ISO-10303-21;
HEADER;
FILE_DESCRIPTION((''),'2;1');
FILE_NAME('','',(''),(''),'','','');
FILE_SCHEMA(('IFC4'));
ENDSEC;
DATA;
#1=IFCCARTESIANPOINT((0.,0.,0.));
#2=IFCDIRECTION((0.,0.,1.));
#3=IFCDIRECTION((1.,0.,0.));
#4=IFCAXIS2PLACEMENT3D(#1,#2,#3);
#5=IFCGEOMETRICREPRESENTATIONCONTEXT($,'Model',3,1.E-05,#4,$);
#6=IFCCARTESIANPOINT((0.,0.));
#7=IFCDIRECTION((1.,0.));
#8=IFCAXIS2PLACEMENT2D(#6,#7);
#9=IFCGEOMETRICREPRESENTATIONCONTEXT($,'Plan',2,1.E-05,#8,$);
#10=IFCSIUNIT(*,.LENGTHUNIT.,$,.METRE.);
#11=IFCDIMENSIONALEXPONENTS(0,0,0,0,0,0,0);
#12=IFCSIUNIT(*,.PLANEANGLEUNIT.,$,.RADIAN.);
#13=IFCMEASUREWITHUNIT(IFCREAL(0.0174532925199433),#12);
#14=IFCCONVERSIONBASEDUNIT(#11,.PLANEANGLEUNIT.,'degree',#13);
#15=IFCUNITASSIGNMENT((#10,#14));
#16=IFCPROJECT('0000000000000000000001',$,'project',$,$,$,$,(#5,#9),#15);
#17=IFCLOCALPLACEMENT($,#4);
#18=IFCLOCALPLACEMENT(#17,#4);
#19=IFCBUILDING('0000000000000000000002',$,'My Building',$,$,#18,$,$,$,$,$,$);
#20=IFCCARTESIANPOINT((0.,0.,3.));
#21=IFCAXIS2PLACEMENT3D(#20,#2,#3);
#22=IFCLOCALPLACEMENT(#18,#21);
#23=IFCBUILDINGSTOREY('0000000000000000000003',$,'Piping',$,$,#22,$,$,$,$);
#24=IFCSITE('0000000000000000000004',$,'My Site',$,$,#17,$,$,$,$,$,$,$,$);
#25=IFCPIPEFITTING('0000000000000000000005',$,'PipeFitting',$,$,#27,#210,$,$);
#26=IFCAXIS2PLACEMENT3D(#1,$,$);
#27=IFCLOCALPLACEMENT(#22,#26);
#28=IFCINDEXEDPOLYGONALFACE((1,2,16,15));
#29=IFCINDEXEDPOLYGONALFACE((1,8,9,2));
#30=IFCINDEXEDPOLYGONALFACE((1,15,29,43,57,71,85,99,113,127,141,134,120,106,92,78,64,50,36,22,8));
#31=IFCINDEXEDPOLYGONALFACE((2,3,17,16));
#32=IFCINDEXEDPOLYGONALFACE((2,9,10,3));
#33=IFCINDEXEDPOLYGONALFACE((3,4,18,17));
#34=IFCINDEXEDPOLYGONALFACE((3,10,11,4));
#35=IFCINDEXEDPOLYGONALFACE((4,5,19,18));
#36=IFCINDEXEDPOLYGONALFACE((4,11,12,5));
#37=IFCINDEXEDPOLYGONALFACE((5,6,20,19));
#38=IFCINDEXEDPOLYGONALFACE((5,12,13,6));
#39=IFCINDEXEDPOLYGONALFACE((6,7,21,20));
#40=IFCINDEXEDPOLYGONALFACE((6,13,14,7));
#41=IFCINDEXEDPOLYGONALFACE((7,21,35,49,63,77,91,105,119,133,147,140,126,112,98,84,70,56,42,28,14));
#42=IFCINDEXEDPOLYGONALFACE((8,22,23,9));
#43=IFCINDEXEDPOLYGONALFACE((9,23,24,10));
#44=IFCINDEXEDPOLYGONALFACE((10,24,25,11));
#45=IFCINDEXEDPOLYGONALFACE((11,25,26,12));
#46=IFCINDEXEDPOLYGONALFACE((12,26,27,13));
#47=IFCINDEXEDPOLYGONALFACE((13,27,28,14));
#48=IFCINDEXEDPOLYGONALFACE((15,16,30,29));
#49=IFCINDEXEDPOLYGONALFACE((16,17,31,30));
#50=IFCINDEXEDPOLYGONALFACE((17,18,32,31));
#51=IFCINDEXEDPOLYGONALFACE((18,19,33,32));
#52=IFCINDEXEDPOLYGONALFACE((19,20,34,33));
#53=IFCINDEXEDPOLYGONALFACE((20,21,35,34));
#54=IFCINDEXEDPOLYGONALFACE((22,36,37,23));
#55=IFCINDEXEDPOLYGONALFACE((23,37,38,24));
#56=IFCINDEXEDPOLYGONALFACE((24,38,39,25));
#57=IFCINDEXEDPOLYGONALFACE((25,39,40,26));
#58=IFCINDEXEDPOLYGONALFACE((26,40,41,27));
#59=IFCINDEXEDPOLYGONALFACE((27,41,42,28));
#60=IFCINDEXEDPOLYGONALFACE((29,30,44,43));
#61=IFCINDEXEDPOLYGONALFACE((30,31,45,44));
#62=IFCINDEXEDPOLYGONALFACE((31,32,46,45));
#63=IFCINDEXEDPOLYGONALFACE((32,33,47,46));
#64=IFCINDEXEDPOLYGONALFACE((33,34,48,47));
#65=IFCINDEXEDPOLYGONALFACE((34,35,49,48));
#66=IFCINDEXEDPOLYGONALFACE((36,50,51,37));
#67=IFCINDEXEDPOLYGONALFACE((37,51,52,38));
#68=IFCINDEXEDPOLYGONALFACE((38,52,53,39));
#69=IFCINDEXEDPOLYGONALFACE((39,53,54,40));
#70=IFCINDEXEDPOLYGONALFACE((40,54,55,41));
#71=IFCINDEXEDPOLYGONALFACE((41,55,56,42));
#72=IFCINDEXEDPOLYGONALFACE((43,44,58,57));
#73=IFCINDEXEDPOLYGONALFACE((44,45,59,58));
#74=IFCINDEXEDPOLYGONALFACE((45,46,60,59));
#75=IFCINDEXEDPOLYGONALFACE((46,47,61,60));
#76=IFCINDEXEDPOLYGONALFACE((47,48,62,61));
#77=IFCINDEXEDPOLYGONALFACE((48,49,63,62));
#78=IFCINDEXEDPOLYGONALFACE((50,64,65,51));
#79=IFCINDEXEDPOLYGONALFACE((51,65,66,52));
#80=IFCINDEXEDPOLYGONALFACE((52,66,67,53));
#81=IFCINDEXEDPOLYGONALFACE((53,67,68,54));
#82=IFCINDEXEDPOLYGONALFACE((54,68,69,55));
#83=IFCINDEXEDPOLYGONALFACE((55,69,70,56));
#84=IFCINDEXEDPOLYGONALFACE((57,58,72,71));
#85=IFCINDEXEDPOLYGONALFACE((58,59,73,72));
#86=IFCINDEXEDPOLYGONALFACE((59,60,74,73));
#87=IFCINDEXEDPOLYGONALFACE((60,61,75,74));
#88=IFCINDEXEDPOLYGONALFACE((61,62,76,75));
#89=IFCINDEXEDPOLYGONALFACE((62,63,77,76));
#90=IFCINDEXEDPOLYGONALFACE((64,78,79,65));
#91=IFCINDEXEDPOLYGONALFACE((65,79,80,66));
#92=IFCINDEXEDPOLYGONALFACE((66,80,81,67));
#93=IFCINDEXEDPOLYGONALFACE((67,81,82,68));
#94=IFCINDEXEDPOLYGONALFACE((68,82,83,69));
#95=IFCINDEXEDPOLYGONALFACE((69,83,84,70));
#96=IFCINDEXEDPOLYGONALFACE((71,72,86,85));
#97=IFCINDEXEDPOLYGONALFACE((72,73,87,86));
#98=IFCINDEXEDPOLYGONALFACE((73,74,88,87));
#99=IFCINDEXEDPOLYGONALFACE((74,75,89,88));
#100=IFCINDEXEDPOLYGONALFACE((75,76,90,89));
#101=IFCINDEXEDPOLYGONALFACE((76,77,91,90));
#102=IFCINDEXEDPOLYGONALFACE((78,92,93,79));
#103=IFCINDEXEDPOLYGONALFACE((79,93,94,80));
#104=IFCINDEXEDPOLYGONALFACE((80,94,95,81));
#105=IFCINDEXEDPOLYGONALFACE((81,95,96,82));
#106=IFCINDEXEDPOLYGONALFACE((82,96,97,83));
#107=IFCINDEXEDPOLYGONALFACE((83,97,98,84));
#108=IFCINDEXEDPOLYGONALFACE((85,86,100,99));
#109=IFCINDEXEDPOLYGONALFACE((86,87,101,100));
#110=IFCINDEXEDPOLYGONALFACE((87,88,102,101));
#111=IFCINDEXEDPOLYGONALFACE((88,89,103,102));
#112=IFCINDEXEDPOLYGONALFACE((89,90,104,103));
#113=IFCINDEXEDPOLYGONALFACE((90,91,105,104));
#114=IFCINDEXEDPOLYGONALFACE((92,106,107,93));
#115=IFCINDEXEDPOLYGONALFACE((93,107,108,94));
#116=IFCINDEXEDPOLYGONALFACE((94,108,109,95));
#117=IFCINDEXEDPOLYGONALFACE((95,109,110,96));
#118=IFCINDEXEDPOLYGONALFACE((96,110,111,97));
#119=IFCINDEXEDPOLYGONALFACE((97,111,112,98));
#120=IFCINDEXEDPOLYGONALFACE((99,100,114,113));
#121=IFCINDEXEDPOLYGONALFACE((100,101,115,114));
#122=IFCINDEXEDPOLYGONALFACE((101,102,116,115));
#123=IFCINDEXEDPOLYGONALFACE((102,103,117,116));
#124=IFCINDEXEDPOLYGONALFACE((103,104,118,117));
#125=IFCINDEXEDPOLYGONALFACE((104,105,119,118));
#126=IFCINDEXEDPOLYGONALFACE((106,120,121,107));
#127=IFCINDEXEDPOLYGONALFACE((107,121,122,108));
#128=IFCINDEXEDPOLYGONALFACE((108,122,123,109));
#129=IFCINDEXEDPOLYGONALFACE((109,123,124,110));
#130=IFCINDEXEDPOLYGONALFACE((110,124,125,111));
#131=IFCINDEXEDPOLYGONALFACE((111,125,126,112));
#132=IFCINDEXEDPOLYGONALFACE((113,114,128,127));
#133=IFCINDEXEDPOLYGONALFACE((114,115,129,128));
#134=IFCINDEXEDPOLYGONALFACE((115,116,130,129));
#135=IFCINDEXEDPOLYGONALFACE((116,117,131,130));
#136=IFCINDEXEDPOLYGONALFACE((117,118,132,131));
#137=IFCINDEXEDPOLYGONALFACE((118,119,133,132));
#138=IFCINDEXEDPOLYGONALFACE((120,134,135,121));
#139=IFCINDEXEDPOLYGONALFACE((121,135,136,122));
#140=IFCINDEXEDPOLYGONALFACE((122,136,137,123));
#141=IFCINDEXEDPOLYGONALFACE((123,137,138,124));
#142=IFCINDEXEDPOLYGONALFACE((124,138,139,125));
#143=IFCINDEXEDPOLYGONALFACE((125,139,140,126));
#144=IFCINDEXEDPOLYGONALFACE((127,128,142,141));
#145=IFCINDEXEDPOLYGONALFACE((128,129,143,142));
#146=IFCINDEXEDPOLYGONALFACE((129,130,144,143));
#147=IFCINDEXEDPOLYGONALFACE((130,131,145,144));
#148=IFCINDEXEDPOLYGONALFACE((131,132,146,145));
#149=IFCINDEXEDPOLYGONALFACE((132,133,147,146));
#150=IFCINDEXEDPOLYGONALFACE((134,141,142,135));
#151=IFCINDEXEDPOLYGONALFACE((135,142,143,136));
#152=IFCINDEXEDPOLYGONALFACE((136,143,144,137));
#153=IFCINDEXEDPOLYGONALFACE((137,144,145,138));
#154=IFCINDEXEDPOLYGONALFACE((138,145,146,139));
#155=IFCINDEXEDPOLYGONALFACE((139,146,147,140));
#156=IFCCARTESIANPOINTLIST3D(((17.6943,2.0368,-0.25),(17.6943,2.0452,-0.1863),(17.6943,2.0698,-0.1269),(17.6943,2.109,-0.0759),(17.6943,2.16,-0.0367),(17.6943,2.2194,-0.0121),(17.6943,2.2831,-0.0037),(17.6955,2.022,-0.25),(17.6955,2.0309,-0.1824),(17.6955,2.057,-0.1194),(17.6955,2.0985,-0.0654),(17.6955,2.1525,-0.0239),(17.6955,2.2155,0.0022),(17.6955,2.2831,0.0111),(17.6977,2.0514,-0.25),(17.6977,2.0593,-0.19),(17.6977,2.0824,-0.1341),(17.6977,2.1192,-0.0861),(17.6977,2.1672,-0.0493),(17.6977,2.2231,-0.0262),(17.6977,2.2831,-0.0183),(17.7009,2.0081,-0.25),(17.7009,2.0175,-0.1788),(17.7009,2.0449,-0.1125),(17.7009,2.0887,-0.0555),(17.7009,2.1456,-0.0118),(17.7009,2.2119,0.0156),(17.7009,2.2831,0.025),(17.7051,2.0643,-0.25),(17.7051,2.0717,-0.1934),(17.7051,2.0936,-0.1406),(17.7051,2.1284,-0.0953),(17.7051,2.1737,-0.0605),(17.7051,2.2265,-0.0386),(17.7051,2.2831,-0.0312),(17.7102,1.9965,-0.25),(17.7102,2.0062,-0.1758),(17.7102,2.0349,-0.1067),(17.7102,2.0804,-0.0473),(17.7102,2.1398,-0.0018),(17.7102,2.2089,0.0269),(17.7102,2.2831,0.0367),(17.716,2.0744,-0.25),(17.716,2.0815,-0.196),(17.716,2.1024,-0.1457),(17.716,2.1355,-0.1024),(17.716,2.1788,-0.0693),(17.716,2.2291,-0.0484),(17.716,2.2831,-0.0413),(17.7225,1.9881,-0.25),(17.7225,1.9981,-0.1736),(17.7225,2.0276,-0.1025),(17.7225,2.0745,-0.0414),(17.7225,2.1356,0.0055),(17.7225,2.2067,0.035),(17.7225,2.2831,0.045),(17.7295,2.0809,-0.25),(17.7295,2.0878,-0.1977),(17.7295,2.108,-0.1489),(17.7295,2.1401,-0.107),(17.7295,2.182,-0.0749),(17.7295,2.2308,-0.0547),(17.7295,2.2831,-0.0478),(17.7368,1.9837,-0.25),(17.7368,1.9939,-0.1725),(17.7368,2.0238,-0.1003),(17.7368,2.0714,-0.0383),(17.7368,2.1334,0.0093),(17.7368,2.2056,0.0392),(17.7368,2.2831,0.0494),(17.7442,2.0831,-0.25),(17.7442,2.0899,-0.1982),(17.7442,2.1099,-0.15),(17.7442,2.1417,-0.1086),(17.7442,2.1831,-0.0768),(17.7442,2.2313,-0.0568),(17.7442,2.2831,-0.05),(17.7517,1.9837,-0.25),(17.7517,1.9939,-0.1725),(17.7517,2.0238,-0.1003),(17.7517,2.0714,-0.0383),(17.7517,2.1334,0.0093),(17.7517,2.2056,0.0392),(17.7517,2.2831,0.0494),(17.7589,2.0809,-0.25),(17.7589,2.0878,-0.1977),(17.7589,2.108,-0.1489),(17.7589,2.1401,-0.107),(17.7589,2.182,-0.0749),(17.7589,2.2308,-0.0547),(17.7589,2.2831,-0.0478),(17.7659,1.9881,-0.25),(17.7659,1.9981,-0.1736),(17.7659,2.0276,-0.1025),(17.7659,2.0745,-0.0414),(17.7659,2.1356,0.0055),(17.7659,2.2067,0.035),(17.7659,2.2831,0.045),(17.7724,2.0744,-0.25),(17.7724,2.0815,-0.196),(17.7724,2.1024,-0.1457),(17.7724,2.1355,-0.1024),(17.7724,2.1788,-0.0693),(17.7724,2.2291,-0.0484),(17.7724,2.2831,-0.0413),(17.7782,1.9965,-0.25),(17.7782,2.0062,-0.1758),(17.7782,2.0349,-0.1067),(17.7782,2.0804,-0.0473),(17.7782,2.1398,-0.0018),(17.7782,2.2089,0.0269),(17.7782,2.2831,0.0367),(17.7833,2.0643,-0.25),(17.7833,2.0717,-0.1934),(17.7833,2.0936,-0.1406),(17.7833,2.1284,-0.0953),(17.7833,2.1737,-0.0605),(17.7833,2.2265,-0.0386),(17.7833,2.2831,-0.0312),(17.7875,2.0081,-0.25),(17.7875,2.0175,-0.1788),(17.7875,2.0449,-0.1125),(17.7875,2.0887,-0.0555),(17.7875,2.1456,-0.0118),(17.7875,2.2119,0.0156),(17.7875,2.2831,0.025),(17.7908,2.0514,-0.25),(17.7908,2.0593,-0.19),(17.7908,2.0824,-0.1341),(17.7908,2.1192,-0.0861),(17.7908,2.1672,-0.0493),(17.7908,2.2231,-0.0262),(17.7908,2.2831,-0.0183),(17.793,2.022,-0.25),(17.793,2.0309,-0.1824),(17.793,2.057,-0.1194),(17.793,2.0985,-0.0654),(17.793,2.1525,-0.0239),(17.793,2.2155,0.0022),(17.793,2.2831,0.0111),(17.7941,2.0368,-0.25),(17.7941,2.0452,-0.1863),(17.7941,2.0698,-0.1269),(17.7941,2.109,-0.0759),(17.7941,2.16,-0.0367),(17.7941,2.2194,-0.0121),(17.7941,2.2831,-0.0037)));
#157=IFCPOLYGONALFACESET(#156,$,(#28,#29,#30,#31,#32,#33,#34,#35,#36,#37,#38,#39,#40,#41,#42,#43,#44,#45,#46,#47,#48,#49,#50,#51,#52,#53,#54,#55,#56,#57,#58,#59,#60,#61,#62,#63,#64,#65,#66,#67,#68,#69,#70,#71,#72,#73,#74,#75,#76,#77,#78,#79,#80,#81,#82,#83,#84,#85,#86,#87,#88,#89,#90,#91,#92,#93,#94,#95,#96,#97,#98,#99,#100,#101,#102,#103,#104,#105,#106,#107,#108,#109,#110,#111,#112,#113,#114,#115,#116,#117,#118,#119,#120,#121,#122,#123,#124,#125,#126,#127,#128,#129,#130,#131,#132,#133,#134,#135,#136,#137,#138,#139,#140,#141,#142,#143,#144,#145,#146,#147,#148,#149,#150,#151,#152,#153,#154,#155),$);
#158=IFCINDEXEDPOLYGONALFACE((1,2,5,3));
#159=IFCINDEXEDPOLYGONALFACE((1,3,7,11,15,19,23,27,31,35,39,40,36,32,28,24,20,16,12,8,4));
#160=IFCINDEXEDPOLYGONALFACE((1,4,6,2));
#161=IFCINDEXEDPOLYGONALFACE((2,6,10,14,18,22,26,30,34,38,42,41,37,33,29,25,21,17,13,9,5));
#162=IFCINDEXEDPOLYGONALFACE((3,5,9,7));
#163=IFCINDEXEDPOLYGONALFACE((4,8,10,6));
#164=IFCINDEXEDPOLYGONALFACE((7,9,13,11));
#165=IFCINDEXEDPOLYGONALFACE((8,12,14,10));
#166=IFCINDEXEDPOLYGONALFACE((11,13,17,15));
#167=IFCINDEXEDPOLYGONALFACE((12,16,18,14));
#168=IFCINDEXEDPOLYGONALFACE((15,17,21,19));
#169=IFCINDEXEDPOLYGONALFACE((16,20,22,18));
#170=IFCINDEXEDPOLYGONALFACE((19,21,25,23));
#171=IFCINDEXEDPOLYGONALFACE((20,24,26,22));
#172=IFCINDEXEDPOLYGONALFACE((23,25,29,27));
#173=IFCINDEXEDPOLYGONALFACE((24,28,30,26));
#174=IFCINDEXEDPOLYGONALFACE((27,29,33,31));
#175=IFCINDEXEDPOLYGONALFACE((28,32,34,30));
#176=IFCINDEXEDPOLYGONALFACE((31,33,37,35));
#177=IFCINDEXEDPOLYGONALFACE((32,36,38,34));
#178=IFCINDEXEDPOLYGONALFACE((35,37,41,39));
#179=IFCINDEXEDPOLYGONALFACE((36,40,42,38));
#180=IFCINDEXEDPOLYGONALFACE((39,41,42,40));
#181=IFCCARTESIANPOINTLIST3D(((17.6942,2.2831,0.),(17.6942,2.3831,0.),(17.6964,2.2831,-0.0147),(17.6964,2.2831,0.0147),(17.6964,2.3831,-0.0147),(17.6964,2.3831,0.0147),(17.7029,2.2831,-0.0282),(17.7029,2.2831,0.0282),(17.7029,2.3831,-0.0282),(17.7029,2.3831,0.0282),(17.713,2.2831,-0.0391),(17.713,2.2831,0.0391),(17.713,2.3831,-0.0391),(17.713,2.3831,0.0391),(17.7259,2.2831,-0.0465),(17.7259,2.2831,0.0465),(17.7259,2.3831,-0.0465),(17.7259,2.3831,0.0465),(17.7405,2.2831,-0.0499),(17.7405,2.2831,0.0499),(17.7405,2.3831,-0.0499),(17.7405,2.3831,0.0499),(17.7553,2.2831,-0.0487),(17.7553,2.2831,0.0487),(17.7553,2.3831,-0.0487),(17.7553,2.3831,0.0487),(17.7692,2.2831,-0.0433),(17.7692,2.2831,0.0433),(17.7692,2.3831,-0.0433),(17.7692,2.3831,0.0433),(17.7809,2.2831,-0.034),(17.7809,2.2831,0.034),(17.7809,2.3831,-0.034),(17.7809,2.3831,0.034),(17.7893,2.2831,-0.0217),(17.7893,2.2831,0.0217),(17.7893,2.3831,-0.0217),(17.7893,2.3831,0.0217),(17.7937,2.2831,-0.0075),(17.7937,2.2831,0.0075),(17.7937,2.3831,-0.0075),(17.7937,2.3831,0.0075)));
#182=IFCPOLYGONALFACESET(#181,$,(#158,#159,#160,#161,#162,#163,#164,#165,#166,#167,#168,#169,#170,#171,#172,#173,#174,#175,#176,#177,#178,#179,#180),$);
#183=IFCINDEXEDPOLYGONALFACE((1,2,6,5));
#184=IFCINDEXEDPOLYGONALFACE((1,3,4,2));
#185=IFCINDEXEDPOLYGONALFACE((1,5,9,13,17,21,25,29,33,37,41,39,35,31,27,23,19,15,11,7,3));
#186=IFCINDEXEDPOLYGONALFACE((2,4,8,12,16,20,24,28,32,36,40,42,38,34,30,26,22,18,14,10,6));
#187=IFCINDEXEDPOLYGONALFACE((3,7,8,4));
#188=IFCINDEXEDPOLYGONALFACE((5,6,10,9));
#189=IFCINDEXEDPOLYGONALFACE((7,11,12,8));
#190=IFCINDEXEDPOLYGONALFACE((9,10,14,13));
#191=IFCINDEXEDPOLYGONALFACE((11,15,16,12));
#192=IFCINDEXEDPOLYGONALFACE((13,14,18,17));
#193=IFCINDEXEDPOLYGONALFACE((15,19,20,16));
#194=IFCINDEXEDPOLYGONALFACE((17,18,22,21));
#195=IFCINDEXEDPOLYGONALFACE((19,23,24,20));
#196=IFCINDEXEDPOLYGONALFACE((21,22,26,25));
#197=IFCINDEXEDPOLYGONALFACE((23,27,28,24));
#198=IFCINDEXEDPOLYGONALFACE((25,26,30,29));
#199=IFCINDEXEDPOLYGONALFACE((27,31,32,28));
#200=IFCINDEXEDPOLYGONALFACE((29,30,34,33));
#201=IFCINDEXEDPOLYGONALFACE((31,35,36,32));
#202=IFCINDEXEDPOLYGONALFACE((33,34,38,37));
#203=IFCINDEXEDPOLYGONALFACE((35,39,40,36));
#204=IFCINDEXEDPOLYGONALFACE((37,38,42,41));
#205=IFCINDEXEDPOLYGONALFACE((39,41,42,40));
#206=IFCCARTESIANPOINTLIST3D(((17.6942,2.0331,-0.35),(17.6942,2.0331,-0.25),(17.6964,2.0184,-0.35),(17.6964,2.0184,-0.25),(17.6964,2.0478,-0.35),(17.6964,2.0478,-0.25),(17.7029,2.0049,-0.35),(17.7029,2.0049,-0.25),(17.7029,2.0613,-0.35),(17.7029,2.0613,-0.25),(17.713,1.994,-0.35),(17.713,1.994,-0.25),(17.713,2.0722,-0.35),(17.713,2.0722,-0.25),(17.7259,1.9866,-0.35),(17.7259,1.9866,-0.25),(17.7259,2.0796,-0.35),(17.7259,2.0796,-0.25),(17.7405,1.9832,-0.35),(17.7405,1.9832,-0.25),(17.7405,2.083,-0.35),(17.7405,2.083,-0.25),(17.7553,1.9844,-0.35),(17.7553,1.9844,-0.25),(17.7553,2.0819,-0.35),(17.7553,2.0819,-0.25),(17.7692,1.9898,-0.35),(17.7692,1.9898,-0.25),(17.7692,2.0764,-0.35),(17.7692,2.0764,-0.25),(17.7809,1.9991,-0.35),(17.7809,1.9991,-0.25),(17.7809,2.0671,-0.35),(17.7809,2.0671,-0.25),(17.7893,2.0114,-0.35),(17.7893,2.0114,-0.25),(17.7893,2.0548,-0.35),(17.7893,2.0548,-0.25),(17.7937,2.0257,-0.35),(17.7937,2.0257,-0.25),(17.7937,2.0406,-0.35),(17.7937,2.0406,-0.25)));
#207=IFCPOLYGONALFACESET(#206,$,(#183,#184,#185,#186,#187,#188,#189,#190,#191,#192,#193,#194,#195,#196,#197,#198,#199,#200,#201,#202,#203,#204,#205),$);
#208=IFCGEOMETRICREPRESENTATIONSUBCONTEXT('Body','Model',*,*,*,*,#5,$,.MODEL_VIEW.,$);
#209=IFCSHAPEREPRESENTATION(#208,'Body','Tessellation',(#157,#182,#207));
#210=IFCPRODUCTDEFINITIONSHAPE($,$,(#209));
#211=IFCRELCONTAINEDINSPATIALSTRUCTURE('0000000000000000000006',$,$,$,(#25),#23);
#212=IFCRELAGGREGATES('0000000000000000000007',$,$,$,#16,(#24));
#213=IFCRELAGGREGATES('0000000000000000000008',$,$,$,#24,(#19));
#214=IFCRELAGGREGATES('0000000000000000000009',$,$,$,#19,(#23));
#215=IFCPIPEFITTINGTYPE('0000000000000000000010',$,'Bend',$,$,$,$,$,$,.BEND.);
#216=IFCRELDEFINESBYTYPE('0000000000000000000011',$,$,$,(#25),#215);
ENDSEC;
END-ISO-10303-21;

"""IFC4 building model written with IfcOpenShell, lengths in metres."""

from ifc_helpers import new_model, entity, si_unit, converted_unit, frame, origin_with_axes, origin_2d_with_axis, place, context, subcontext, project, spatial, circle, extrude, source, transform, mapped, type_object, type_shapes, element, save


model = new_model("IFC4")

# Units and contexts
model_context = context("Model", 3, precision=1e-05, world=origin_with_axes())
plan_context = context("Plan", 2, precision=1e-05, world=origin_2d_with_axis())
body_context = subcontext(model_context, "Body", "Model", "MODEL_VIEW")
ifc_project = project(units=[si_unit("LENGTHUNIT", "METRE"), converted_unit("PLANEANGLEUNIT", "degree", entity("IfcReal", 0.0174532925199433), si_unit("PLANEANGLEUNIT", "RADIAN"), dimensions=[0, 0, 0, 0, 0, 0, 0])], contexts=[model_context, plan_context])

# Site, building, storey
site_placement = place(None, origin_with_axes())
site = spatial("IfcSite", under=ifc_project, at=site_placement, Name="My Site")
building_placement = place(site_placement, origin_with_axes())
building = spatial("IfcBuilding", under=site, at=building_placement, Name="My Building")
storey_placement = place(building_placement, frame((0.0, 0.0, 3.0), z_axis=(0.0, 0.0, 1.0), x_axis=(1.0, 0.0, 0.0)))
storey = spatial("IfcBuildingStorey", under=building, at=storey_placement, Name="Piping")

# Pipe fitting
pipe_fitting_type = type_object("IfcPipeFittingType", Name="Bend", PredefinedType="BEND")
shared_shape = source(origin_with_axes(), body_context, "Body", "SolidModel", [
    entity("IfcSweptDiskSolid", entity("IfcIndexedPolyCurve", entity("IfcCartesianPointList3D", [[0.0, 0.0, -0.1], [0.0, -0.0732, -0.2768], [0.0, -0.25, -0.35]]), [entity("IfcArcIndex", [1, 2, 3])]), 0.05),
    extrude(circle(Radius=0.05), origin_with_axes(), (0.0, 0.0, -1.0), 0.1),
    extrude(circle(Radius=0.05), frame((0.0, -0.25, -0.35), z_axis=(0.0, -1.0, 0.0), x_axis=(1.0, 0.0, 0.0)), (0.0, 0.0, 1.0), 0.1),
])
type_shapes(pipe_fitting_type, [shared_shape])
for number, where, z_axis, x_axis, name in (
    (1, (17.7442, 2.3831, 0.0), (0.0, 1.0, 0.0), (-1.0, 0.0, 0.0), "PipeFitting"),
):
    element("IfcPipeFitting", number, at=place(storey_placement, frame(where, z_axis=z_axis, x_axis=x_axis)), inside=storey, type_object=pipe_fitting_type, Name=name, context=body_context, shape_type="MappedRepresentation", body=[
        mapped(shared_shape, transform((0.0, 0.0, 0.0), x_axis=(1.0, 0.0, 0.0), y_axis=(0.0, 1.0, 0.0), z_axis=(0.0, 0.0, 1.0), scale=1.0)),
    ])

save(model, "model.ifc")
